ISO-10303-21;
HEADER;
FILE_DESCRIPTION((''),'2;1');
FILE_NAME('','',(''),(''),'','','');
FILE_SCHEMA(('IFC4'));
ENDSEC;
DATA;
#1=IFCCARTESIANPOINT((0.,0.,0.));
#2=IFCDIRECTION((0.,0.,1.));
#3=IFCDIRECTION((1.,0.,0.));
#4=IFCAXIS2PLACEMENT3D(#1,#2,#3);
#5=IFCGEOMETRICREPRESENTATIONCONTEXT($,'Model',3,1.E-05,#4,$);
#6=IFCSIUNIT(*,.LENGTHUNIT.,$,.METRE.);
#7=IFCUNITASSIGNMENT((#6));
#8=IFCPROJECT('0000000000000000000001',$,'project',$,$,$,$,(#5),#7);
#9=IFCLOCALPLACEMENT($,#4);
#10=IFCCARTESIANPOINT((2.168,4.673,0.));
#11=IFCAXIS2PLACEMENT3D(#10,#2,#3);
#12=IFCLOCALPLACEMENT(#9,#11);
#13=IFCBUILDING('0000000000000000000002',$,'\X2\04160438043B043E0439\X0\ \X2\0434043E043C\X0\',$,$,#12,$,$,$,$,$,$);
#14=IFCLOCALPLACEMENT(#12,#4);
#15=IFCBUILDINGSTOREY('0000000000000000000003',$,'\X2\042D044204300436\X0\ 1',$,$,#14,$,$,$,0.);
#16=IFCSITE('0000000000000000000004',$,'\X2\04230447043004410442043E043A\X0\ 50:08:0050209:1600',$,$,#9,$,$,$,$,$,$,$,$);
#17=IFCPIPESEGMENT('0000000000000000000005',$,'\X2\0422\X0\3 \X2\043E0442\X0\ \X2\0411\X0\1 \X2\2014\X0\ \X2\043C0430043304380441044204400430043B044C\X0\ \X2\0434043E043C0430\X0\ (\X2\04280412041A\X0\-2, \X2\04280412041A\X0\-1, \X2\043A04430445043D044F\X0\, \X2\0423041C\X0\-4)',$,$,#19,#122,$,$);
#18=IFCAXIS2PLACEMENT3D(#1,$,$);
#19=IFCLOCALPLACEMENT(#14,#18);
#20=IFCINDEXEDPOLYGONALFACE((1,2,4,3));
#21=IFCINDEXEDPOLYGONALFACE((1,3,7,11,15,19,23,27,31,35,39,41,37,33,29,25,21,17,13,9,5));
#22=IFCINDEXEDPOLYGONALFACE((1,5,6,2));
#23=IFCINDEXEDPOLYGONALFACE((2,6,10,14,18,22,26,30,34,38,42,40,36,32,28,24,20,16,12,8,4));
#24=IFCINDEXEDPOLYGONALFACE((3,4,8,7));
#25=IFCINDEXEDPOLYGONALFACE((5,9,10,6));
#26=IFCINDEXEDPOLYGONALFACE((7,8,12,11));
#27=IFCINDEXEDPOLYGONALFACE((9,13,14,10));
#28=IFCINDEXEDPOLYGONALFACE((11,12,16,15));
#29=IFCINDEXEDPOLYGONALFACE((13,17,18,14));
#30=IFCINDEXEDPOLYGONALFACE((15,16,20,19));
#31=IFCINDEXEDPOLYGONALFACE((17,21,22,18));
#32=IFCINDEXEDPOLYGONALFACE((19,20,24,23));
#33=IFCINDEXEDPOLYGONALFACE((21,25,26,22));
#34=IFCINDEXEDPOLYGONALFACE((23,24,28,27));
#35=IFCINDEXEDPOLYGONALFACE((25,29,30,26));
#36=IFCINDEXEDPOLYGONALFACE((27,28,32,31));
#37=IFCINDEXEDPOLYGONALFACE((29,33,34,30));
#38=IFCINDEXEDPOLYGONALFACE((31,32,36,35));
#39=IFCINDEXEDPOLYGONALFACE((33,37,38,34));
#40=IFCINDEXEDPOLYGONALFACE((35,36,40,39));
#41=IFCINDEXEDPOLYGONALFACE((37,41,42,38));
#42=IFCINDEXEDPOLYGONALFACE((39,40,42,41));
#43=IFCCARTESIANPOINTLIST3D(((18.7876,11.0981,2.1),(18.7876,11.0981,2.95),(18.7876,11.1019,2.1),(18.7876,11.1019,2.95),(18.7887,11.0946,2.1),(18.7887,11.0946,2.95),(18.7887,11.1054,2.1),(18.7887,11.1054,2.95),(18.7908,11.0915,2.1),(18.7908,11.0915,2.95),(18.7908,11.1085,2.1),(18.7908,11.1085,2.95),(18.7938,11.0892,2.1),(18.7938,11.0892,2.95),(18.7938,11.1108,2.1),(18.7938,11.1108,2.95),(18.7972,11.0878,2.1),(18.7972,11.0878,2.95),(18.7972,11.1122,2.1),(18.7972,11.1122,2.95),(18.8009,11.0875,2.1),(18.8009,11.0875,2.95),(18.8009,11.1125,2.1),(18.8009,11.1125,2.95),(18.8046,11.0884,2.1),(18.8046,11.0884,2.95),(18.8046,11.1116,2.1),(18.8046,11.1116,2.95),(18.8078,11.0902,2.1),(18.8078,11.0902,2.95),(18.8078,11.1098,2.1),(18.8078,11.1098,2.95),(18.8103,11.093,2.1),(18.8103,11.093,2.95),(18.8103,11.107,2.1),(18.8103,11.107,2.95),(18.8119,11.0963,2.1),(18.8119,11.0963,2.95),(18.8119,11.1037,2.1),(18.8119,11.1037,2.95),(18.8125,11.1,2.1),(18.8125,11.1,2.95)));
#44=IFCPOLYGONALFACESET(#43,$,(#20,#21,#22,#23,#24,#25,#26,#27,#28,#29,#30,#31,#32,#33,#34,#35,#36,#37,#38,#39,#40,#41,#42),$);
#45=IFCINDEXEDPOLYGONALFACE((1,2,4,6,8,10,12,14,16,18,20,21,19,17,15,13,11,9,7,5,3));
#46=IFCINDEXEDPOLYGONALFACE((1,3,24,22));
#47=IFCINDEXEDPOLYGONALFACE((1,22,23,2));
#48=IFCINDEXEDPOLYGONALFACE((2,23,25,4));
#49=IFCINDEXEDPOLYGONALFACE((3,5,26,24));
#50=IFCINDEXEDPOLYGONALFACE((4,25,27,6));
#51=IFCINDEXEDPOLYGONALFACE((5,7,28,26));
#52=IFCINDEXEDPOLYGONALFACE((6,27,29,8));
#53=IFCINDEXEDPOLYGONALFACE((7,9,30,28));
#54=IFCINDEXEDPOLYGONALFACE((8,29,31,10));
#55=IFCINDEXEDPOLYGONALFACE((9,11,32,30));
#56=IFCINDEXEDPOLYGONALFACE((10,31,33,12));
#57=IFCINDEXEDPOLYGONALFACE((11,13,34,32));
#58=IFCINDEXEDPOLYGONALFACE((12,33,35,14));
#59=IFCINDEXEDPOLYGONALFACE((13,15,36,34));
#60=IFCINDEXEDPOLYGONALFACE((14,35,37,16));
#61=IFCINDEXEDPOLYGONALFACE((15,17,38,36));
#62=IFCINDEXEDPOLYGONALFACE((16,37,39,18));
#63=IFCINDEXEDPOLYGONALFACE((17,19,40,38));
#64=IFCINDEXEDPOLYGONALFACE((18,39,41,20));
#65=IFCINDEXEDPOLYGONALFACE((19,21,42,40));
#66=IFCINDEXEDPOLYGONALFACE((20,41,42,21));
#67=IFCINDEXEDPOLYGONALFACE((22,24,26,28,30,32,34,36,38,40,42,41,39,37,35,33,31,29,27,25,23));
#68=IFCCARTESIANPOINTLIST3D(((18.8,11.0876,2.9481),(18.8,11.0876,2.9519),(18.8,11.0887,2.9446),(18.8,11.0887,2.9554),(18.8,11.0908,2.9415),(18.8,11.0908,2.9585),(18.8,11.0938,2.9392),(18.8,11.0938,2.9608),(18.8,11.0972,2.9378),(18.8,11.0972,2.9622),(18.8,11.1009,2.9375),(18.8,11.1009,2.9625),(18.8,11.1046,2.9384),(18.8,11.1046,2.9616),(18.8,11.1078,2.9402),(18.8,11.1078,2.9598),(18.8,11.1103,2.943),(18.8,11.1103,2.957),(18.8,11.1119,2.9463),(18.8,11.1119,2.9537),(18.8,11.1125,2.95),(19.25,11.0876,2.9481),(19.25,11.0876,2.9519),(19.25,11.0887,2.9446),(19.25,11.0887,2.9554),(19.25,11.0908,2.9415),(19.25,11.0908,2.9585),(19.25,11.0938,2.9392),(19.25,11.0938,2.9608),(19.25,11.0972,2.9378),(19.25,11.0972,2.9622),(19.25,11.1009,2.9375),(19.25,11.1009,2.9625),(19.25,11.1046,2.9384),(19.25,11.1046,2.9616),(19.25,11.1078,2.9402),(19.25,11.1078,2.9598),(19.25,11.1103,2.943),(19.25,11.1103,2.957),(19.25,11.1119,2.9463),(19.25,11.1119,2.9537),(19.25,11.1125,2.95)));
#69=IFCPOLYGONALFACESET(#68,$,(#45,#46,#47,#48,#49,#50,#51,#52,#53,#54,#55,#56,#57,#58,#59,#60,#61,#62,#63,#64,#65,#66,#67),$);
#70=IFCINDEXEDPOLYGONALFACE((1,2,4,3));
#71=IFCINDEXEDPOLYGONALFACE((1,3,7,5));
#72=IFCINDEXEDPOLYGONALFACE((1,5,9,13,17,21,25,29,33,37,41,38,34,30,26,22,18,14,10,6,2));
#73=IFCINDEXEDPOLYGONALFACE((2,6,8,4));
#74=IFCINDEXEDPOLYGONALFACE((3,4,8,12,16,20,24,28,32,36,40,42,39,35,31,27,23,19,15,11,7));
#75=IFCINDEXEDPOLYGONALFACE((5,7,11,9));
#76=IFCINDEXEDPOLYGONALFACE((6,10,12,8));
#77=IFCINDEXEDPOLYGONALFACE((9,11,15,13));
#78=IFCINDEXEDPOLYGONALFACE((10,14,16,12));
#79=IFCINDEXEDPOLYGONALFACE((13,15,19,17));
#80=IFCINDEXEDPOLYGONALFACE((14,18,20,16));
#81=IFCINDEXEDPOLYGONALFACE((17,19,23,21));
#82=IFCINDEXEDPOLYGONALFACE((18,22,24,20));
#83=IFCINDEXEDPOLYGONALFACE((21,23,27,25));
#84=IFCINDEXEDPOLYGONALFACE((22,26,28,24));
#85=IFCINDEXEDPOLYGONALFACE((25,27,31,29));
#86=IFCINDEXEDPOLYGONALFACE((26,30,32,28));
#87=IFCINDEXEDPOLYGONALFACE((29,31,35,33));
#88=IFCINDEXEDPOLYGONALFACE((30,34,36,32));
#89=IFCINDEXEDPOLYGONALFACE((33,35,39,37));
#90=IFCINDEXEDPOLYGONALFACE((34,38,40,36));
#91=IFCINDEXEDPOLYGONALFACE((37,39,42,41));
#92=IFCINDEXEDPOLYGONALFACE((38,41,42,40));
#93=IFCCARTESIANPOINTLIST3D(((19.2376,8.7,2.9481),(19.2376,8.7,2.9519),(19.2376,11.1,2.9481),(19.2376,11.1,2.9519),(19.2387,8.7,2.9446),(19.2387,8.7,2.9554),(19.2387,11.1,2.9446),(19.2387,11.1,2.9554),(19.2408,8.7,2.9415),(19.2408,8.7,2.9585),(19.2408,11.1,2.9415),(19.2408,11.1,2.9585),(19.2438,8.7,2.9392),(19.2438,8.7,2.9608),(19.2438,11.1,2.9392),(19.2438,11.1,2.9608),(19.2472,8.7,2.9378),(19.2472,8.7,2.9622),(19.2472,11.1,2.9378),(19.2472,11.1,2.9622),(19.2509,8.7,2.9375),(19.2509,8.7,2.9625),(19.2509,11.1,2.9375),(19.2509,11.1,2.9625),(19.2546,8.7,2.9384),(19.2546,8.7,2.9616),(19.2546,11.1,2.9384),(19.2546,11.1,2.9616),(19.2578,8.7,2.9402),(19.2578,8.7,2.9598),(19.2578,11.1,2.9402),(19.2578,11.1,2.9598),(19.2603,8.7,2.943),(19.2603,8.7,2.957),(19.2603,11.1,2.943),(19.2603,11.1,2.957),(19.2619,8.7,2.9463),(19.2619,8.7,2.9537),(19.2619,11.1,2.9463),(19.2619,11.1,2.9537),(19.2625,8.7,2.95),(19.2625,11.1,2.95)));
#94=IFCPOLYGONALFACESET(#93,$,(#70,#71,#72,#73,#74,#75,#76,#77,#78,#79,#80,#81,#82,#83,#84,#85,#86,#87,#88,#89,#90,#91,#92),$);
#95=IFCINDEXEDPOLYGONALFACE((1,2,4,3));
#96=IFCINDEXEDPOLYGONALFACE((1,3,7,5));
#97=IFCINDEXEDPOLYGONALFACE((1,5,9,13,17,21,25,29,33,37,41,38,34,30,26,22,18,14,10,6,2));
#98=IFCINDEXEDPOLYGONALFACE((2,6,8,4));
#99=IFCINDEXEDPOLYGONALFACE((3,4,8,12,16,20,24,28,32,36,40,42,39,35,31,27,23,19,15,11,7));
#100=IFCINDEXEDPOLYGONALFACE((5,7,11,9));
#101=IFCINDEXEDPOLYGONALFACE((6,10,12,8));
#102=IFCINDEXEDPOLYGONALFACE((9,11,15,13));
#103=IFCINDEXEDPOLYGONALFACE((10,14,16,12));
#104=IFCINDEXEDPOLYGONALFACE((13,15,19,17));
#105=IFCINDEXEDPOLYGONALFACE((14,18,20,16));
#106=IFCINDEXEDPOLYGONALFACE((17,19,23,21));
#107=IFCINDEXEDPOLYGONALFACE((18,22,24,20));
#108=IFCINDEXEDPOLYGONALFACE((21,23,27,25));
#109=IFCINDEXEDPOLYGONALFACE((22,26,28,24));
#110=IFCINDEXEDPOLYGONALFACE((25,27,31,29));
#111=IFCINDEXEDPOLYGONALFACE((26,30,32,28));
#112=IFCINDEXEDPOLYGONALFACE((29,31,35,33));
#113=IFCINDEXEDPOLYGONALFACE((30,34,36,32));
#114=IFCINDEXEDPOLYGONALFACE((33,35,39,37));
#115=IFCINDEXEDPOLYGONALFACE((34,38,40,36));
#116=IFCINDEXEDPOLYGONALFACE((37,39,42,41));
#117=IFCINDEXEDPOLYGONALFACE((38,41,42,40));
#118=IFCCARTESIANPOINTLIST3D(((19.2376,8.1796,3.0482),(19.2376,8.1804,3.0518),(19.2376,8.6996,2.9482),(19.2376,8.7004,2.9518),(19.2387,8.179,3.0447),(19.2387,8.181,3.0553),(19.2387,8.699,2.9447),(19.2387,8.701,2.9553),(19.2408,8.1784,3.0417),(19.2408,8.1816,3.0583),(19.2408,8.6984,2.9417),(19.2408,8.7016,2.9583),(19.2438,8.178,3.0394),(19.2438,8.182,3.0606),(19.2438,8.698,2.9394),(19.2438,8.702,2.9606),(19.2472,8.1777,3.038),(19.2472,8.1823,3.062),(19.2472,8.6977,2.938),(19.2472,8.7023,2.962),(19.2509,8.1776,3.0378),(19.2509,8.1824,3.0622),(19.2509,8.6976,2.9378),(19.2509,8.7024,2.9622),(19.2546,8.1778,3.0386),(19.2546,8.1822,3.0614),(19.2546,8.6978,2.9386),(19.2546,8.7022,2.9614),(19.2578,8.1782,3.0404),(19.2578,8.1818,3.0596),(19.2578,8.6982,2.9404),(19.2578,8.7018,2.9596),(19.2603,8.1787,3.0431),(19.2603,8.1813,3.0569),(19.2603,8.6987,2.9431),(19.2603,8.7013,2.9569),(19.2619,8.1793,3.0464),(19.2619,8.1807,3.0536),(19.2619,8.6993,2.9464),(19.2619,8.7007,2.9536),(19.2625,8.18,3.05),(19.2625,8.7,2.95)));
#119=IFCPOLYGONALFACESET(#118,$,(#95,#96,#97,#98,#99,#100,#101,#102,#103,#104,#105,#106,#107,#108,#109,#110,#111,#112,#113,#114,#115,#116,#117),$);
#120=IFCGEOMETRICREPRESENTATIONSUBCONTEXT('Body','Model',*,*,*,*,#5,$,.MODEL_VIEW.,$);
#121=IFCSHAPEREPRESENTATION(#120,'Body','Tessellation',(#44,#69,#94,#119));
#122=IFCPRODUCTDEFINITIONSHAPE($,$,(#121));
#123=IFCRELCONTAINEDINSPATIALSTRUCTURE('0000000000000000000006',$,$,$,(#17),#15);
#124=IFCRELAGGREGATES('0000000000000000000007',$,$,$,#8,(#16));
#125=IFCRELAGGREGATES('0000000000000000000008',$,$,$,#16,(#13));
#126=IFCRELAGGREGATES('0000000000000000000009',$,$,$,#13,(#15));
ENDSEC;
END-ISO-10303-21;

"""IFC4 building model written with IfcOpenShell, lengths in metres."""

from ifc_helpers import new_model, si_unit, frame, origin_with_axes, origin_2d, place, context, subcontext, project, spatial, circle, extrude, element, save


model = new_model("IFC4")

# Units and contexts
model_context = context("Model", 3, precision=1e-05, world=origin_with_axes())
body_context = subcontext(model_context, "Body", "Model", "MODEL_VIEW")
ifc_project = project(units=[si_unit("LENGTHUNIT", "METRE")], contexts=[model_context])

# Site, building, storey
site_placement = place(None, origin_with_axes())
site = spatial("IfcSite", under=ifc_project, at=site_placement, Name="Участок 50:08:0050209:1600")
building_placement = place(site_placement, frame((2.168, 4.673, 0.0), z_axis=(0.0, 0.0, 1.0), x_axis=(1.0, 0.0, 0.0)))
building = spatial("IfcBuilding", under=site, at=building_placement, Name="Жилой дом")
storey_placement = place(building_placement, origin_with_axes())
storey = spatial("IfcBuildingStorey", under=building, at=storey_placement, Name="Этаж 1", Elevation=0.0)

# Pipe segment
pipe_segment_1_placement = place(storey_placement, origin_with_axes())
element("IfcPipeSegment", 1, at=pipe_segment_1_placement, inside=storey, Name="Т3 от Б1 — магистраль дома (ШВК-2, ШВК-1, кухня, УМ-4)", context=body_context, shape_type="SweptSolid", body=[
    extrude(circle(Radius=0.0125, at=origin_2d()), frame((18.8, 11.1, 2.1), z_axis=(0.0, 0.0, 1.0), x_axis=(1.0, 0.0, 0.0)), (0.0, 0.0, 1.0), 0.85),
    extrude(circle(Radius=0.0125, at=origin_2d()), frame((18.8, 11.1, 2.95), z_axis=(1.0, 0.0, 0.0), x_axis=(0.0, 1.0, 0.0)), (0.0, 0.0, 1.0), 0.45),
    extrude(circle(Radius=0.0125, at=origin_2d()), frame((19.25, 11.1, 2.95), z_axis=(0.0, -1.0, 0.0), x_axis=(1.0, 0.0, 0.0)), (0.0, 0.0, 1.0), 2.4),
    extrude(circle(Radius=0.0125, at=origin_2d()), frame((19.25, 8.7, 2.95), z_axis=(0.0, -0.982006, 0.188847), x_axis=(1.0, 0.0, 0.0)), (0.0, 0.0, 1.0), 0.5295),
])

save(model, "model.ifc")
